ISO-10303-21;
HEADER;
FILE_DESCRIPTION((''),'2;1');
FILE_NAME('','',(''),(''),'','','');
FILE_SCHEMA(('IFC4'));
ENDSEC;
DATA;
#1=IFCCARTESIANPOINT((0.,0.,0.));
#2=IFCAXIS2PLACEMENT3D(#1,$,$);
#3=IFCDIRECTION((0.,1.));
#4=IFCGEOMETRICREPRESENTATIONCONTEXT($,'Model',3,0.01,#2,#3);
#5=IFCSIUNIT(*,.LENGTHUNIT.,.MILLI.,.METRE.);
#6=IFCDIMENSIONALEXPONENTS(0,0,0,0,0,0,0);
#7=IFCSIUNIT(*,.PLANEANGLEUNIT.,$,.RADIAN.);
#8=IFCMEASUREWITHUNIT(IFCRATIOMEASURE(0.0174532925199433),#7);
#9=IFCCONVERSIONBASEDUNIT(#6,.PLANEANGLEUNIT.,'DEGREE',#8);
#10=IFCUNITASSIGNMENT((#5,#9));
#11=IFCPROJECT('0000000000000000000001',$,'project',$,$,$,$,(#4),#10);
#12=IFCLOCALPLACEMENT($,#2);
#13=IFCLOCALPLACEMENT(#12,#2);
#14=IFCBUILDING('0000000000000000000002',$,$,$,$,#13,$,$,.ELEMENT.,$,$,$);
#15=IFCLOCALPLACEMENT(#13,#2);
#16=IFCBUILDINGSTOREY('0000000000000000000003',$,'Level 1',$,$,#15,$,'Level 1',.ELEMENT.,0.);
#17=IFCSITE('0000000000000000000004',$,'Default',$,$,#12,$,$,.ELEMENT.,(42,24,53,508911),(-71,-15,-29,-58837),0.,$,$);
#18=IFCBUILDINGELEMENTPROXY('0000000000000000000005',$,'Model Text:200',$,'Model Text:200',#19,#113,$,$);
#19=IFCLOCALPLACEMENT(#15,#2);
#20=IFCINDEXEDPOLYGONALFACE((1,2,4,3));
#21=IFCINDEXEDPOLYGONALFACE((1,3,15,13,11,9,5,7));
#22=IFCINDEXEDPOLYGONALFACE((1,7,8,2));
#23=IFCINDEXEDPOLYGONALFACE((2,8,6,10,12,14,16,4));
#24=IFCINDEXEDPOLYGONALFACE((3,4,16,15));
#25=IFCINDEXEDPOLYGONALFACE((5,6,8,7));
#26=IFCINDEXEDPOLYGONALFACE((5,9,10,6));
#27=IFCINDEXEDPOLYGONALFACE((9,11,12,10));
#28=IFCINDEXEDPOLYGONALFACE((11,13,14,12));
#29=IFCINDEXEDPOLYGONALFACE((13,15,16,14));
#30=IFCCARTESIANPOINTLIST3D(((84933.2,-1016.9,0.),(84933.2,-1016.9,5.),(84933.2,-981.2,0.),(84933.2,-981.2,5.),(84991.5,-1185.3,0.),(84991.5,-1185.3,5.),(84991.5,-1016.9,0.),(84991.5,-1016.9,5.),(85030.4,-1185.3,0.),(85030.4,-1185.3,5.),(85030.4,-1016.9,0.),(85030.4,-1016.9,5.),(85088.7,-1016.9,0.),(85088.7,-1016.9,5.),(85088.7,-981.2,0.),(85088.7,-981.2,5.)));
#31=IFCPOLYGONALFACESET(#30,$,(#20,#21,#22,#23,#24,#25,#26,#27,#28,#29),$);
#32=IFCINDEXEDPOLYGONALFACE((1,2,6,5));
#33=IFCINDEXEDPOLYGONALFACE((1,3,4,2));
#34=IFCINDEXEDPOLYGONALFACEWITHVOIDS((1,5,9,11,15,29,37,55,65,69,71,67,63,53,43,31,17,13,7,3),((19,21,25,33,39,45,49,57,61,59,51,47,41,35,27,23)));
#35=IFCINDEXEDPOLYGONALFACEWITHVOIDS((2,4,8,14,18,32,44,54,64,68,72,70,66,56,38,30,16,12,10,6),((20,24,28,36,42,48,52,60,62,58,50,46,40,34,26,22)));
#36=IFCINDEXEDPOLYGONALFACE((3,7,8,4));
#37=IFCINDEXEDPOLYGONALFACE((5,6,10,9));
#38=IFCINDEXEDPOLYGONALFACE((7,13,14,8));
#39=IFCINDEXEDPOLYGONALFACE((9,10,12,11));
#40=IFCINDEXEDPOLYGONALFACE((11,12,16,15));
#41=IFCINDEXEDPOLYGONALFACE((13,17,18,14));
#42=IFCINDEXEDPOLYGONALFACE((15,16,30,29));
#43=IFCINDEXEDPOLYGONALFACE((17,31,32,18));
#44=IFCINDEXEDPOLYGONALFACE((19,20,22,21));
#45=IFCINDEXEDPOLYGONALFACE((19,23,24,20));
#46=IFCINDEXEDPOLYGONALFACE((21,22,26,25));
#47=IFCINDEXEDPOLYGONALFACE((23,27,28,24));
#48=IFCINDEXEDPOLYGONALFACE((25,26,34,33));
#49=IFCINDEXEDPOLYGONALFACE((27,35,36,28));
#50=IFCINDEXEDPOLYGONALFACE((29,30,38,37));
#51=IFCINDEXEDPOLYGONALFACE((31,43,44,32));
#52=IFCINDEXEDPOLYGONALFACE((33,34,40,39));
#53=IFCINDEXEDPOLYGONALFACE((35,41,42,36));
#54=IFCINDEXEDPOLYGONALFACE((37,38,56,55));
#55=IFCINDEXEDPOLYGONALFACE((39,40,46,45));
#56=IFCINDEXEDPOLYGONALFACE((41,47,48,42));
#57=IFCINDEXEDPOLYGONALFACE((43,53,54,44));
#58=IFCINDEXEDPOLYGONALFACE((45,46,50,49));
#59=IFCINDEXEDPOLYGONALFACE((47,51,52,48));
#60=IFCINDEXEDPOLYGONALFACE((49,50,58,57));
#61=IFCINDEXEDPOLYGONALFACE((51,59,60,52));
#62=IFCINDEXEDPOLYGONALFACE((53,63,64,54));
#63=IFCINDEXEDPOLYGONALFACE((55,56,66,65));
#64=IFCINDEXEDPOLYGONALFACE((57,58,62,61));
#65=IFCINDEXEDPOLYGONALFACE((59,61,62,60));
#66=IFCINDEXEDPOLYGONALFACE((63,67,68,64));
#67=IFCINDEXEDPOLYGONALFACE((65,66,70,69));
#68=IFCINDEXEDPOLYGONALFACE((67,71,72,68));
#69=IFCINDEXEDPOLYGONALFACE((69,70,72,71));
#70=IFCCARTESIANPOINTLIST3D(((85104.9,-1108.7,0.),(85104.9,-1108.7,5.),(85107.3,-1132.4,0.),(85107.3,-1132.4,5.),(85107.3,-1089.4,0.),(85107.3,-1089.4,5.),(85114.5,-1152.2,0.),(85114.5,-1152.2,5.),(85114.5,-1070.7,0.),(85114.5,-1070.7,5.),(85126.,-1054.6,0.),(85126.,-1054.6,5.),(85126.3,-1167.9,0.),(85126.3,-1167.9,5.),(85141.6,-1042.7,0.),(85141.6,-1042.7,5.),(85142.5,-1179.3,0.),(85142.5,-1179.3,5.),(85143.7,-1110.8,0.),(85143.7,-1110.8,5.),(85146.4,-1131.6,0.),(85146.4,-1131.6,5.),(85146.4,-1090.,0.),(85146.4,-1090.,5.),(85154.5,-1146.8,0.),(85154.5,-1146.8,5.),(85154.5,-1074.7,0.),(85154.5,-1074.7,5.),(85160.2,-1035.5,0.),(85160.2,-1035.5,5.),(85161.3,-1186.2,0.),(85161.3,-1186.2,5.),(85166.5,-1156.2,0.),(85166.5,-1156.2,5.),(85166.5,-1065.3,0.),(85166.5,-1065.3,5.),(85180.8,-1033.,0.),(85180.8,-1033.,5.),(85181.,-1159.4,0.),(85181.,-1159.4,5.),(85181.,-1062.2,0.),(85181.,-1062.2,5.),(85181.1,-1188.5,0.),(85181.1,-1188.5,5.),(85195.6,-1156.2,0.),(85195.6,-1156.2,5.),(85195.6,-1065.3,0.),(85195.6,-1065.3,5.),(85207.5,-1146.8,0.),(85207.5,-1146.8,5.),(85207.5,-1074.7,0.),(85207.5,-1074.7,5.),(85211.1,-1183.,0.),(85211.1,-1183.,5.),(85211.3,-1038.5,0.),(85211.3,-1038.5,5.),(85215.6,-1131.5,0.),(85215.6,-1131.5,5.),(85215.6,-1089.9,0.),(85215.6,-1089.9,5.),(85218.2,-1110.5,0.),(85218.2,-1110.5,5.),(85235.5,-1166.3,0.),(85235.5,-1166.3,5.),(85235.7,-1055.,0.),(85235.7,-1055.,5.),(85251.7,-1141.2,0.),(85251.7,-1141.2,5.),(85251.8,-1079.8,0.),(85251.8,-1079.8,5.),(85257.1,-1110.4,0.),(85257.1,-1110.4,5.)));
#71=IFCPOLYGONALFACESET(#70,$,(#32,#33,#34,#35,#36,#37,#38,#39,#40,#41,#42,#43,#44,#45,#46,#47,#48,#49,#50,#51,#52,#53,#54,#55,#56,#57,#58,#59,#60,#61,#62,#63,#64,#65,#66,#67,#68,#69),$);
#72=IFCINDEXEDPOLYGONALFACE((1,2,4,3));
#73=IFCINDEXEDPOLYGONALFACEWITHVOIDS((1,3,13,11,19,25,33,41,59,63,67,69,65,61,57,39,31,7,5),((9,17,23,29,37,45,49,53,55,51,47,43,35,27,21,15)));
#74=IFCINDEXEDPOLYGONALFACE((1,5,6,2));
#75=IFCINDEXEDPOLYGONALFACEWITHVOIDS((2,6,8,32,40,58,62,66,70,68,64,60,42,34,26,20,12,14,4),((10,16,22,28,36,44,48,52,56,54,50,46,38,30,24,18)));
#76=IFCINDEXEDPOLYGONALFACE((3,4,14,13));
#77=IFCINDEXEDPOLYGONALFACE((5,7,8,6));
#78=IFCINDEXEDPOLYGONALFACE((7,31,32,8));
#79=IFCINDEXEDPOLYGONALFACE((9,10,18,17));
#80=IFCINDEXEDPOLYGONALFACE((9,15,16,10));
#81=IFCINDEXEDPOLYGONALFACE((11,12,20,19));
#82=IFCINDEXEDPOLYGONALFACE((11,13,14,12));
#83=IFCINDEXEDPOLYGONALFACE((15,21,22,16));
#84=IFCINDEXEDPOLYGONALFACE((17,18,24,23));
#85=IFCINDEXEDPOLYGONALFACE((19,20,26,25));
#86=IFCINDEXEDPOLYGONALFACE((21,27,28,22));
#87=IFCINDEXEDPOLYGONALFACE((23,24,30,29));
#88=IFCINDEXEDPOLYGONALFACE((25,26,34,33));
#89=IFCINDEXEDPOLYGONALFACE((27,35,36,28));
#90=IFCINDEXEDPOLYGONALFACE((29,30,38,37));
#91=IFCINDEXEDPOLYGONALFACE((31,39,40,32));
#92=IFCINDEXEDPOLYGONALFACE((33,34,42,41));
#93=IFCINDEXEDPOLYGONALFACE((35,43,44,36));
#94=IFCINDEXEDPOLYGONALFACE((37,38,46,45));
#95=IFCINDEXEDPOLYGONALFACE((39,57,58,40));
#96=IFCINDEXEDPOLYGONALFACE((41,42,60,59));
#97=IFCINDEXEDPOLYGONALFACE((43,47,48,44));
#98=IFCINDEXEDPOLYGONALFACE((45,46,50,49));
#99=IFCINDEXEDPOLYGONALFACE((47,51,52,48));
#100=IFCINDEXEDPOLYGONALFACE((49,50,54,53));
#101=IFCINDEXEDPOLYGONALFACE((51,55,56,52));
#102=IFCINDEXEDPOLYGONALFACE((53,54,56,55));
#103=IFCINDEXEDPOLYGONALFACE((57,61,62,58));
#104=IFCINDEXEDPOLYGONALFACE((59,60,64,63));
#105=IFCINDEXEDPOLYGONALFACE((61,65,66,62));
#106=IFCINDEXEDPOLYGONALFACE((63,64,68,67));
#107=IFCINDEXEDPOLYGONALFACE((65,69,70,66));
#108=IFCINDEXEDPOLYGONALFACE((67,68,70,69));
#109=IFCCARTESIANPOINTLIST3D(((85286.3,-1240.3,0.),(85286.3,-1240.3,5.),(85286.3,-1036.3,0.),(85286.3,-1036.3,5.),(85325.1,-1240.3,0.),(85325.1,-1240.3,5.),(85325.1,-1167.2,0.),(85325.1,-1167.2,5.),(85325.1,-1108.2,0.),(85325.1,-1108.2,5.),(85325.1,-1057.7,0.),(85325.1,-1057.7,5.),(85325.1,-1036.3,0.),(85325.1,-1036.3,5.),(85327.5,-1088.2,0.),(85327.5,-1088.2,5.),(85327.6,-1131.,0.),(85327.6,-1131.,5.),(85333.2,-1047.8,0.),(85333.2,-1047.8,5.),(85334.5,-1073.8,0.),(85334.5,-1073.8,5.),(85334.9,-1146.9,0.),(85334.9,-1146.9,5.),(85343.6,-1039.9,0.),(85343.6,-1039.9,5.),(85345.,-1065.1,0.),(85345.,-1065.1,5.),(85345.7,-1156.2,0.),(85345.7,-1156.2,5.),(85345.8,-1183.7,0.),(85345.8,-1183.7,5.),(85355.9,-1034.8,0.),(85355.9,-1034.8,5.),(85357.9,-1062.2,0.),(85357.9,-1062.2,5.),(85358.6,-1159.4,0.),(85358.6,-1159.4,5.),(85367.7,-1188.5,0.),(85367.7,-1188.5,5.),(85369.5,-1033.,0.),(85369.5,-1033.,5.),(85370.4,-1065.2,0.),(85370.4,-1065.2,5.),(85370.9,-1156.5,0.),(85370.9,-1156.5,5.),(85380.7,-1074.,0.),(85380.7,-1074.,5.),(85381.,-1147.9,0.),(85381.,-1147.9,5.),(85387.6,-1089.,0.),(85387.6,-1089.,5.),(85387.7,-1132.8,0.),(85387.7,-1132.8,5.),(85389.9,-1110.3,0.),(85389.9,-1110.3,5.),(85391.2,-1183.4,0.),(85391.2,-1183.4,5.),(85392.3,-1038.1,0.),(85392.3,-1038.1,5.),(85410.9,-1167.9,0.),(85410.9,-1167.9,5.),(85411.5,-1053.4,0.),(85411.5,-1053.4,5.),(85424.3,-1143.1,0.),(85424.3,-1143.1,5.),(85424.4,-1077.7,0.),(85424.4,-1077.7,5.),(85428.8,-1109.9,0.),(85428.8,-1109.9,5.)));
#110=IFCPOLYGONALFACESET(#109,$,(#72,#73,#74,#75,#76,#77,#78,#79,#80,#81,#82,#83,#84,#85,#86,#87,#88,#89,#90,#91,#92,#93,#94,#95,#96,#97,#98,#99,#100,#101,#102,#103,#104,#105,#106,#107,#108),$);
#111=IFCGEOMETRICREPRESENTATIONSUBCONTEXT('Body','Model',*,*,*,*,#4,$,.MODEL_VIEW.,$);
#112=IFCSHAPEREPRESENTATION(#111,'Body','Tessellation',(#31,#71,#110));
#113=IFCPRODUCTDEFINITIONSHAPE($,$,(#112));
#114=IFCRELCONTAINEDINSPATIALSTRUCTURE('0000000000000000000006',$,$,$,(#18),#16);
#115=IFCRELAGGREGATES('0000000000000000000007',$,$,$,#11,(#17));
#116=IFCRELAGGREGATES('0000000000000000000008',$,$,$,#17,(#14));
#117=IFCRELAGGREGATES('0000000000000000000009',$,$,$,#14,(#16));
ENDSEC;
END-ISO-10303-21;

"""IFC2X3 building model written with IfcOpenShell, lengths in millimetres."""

from ifc_helpers import new_model, entity, si_unit, converted_unit, direction, frame, origin, place, context, subcontext, project, spatial, polyline, outline, extrude, element, save


model = new_model("IFC2X3")

# Units and contexts
model_context = context("Model", 3, precision=0.01, world=origin(), true_north=direction((0.0, 1.0)))
body_context = subcontext(model_context, "Body", "Model", "MODEL_VIEW")
ifc_project = project(units=[si_unit("LENGTHUNIT", "METRE", prefix="MILLI"), converted_unit("PLANEANGLEUNIT", "DEGREE", entity("IfcRatioMeasure", 0.0174532925199433), si_unit("PLANEANGLEUNIT", "RADIAN"), dimensions=[0, 0, 0, 0, 0, 0, 0])], contexts=[model_context])

# Site, building, storey
site_placement = place(None, origin())
site = spatial("IfcSite", under=ifc_project, at=site_placement, Name="Default", CompositionType="ELEMENT", RefLatitude=(42, 24, 53, 508911), RefLongitude=(-71, -15, -29, -58837), RefElevation=0.0)
building_placement = place(site_placement, origin())
building = spatial("IfcBuilding", under=site, at=building_placement, CompositionType="ELEMENT")
storey_placement = place(building_placement, origin())
storey = spatial("IfcBuildingStorey", under=building, at=storey_placement, Name="Level 1", LongName="Level 1", CompositionType="ELEMENT", Elevation=0.0)

# Building element proxy
proxy_1_placement = place(storey_placement, origin())
element("IfcBuildingElementProxy", 1, at=proxy_1_placement, inside=storey, Name="Model Text:200", ObjectType="Model Text:200", context=body_context, shape_type="SweptSolid", body=[
    extrude(outline(polyline([(-19.4, -135.2), (19.4, -135.2), (19.4, 33.2), (77.7, 33.2), (77.7, 68.8), (-77.7, 68.8), (-77.7, 33.2), (-19.4, 33.2), (-19.4, -135.2)])), frame((85010.9, -1050.1, 0.0)), (0.0, 0.0, 1.0), 5.0),
    extrude(outline(polyline([(-8.8, -65.7), (15.1, -65.7), (35.5, -60.5), (52.3, -50.4), (65.3, -35.4), (74.1, -17.3), (78.4, 2.1), (75.9, 32.5), (61.8, 58.5), (38.4, 77.1), (8.3, 85.6), (-22.7, 83.3), (-49.0, 69.9), (-67.8, 47.3), (-76.3, 17.5), (-76.0, -3.3), (-70.7, -22.5), (-60.5, -39.2), (-45.5, -52.3), (-27.7, -61.4), (-8.8, -65.7)]), holes=[polyline([(-2.7, -27.2), (-23.1, -22.5), (-37.5, -12.9), (-45.7, 0.0), (-47.3, 14.8), (-42.7, 28.9), (-32.2, 39.9), (-16.3, 46.3), (4.5, 46.9), (25.1, 42.1), (39.6, 32.6), (47.7, 19.7), (49.4, 5.0), (44.8, -9.2), (34.2, -20.2), (18.2, -26.7), (-2.7, -27.2)])]), frame((85171.1, -1110.8, 0.0), z_axis=(0.0, 0.0, 1.0), x_axis=(0.100608, -0.994926, 0.0)), (0.0, 0.0, 1.0), 5.0),
    extrude(outline(polyline([(-73.1, -75.4), (130.9, -75.4), (130.9, -36.6), (57.8, -36.6), (74.3, -15.9), (79.1, 6.0), (73.9, 29.5), (58.4, 49.2), (33.6, 62.6), (0.5, 67.1), (-31.8, 62.8), (-56.1, 49.8), (-71.3, 30.7), (-76.4, 7.8), (-74.7, -5.8), (-69.6, -18.1), (-61.7, -28.5), (-51.7, -36.6), (-73.1, -36.6), (-73.1, -75.4)]), holes=[polyline([(-1.2, -36.6), (-21.2, -34.2), (-35.6, -27.2), (-44.3, -16.7), (-47.2, -3.8), (-44.3, 8.7), (-35.4, 19.0), (-20.4, 25.9), (0.8, 28.2), (23.3, 26.0), (38.5, 19.3), (47.1, 9.2), (49.9, -3.1), (46.8, -16.0), (37.4, -26.8), (21.5, -34.1), (-1.2, -36.6)])]), frame((85361.7, -1109.4, 0.0), z_axis=(0.0, 0.0, 1.0), x_axis=(0.0, -1.0, 0.0)), (0.0, 0.0, 1.0), 5.0),
])

save(model, "model.ifc")
